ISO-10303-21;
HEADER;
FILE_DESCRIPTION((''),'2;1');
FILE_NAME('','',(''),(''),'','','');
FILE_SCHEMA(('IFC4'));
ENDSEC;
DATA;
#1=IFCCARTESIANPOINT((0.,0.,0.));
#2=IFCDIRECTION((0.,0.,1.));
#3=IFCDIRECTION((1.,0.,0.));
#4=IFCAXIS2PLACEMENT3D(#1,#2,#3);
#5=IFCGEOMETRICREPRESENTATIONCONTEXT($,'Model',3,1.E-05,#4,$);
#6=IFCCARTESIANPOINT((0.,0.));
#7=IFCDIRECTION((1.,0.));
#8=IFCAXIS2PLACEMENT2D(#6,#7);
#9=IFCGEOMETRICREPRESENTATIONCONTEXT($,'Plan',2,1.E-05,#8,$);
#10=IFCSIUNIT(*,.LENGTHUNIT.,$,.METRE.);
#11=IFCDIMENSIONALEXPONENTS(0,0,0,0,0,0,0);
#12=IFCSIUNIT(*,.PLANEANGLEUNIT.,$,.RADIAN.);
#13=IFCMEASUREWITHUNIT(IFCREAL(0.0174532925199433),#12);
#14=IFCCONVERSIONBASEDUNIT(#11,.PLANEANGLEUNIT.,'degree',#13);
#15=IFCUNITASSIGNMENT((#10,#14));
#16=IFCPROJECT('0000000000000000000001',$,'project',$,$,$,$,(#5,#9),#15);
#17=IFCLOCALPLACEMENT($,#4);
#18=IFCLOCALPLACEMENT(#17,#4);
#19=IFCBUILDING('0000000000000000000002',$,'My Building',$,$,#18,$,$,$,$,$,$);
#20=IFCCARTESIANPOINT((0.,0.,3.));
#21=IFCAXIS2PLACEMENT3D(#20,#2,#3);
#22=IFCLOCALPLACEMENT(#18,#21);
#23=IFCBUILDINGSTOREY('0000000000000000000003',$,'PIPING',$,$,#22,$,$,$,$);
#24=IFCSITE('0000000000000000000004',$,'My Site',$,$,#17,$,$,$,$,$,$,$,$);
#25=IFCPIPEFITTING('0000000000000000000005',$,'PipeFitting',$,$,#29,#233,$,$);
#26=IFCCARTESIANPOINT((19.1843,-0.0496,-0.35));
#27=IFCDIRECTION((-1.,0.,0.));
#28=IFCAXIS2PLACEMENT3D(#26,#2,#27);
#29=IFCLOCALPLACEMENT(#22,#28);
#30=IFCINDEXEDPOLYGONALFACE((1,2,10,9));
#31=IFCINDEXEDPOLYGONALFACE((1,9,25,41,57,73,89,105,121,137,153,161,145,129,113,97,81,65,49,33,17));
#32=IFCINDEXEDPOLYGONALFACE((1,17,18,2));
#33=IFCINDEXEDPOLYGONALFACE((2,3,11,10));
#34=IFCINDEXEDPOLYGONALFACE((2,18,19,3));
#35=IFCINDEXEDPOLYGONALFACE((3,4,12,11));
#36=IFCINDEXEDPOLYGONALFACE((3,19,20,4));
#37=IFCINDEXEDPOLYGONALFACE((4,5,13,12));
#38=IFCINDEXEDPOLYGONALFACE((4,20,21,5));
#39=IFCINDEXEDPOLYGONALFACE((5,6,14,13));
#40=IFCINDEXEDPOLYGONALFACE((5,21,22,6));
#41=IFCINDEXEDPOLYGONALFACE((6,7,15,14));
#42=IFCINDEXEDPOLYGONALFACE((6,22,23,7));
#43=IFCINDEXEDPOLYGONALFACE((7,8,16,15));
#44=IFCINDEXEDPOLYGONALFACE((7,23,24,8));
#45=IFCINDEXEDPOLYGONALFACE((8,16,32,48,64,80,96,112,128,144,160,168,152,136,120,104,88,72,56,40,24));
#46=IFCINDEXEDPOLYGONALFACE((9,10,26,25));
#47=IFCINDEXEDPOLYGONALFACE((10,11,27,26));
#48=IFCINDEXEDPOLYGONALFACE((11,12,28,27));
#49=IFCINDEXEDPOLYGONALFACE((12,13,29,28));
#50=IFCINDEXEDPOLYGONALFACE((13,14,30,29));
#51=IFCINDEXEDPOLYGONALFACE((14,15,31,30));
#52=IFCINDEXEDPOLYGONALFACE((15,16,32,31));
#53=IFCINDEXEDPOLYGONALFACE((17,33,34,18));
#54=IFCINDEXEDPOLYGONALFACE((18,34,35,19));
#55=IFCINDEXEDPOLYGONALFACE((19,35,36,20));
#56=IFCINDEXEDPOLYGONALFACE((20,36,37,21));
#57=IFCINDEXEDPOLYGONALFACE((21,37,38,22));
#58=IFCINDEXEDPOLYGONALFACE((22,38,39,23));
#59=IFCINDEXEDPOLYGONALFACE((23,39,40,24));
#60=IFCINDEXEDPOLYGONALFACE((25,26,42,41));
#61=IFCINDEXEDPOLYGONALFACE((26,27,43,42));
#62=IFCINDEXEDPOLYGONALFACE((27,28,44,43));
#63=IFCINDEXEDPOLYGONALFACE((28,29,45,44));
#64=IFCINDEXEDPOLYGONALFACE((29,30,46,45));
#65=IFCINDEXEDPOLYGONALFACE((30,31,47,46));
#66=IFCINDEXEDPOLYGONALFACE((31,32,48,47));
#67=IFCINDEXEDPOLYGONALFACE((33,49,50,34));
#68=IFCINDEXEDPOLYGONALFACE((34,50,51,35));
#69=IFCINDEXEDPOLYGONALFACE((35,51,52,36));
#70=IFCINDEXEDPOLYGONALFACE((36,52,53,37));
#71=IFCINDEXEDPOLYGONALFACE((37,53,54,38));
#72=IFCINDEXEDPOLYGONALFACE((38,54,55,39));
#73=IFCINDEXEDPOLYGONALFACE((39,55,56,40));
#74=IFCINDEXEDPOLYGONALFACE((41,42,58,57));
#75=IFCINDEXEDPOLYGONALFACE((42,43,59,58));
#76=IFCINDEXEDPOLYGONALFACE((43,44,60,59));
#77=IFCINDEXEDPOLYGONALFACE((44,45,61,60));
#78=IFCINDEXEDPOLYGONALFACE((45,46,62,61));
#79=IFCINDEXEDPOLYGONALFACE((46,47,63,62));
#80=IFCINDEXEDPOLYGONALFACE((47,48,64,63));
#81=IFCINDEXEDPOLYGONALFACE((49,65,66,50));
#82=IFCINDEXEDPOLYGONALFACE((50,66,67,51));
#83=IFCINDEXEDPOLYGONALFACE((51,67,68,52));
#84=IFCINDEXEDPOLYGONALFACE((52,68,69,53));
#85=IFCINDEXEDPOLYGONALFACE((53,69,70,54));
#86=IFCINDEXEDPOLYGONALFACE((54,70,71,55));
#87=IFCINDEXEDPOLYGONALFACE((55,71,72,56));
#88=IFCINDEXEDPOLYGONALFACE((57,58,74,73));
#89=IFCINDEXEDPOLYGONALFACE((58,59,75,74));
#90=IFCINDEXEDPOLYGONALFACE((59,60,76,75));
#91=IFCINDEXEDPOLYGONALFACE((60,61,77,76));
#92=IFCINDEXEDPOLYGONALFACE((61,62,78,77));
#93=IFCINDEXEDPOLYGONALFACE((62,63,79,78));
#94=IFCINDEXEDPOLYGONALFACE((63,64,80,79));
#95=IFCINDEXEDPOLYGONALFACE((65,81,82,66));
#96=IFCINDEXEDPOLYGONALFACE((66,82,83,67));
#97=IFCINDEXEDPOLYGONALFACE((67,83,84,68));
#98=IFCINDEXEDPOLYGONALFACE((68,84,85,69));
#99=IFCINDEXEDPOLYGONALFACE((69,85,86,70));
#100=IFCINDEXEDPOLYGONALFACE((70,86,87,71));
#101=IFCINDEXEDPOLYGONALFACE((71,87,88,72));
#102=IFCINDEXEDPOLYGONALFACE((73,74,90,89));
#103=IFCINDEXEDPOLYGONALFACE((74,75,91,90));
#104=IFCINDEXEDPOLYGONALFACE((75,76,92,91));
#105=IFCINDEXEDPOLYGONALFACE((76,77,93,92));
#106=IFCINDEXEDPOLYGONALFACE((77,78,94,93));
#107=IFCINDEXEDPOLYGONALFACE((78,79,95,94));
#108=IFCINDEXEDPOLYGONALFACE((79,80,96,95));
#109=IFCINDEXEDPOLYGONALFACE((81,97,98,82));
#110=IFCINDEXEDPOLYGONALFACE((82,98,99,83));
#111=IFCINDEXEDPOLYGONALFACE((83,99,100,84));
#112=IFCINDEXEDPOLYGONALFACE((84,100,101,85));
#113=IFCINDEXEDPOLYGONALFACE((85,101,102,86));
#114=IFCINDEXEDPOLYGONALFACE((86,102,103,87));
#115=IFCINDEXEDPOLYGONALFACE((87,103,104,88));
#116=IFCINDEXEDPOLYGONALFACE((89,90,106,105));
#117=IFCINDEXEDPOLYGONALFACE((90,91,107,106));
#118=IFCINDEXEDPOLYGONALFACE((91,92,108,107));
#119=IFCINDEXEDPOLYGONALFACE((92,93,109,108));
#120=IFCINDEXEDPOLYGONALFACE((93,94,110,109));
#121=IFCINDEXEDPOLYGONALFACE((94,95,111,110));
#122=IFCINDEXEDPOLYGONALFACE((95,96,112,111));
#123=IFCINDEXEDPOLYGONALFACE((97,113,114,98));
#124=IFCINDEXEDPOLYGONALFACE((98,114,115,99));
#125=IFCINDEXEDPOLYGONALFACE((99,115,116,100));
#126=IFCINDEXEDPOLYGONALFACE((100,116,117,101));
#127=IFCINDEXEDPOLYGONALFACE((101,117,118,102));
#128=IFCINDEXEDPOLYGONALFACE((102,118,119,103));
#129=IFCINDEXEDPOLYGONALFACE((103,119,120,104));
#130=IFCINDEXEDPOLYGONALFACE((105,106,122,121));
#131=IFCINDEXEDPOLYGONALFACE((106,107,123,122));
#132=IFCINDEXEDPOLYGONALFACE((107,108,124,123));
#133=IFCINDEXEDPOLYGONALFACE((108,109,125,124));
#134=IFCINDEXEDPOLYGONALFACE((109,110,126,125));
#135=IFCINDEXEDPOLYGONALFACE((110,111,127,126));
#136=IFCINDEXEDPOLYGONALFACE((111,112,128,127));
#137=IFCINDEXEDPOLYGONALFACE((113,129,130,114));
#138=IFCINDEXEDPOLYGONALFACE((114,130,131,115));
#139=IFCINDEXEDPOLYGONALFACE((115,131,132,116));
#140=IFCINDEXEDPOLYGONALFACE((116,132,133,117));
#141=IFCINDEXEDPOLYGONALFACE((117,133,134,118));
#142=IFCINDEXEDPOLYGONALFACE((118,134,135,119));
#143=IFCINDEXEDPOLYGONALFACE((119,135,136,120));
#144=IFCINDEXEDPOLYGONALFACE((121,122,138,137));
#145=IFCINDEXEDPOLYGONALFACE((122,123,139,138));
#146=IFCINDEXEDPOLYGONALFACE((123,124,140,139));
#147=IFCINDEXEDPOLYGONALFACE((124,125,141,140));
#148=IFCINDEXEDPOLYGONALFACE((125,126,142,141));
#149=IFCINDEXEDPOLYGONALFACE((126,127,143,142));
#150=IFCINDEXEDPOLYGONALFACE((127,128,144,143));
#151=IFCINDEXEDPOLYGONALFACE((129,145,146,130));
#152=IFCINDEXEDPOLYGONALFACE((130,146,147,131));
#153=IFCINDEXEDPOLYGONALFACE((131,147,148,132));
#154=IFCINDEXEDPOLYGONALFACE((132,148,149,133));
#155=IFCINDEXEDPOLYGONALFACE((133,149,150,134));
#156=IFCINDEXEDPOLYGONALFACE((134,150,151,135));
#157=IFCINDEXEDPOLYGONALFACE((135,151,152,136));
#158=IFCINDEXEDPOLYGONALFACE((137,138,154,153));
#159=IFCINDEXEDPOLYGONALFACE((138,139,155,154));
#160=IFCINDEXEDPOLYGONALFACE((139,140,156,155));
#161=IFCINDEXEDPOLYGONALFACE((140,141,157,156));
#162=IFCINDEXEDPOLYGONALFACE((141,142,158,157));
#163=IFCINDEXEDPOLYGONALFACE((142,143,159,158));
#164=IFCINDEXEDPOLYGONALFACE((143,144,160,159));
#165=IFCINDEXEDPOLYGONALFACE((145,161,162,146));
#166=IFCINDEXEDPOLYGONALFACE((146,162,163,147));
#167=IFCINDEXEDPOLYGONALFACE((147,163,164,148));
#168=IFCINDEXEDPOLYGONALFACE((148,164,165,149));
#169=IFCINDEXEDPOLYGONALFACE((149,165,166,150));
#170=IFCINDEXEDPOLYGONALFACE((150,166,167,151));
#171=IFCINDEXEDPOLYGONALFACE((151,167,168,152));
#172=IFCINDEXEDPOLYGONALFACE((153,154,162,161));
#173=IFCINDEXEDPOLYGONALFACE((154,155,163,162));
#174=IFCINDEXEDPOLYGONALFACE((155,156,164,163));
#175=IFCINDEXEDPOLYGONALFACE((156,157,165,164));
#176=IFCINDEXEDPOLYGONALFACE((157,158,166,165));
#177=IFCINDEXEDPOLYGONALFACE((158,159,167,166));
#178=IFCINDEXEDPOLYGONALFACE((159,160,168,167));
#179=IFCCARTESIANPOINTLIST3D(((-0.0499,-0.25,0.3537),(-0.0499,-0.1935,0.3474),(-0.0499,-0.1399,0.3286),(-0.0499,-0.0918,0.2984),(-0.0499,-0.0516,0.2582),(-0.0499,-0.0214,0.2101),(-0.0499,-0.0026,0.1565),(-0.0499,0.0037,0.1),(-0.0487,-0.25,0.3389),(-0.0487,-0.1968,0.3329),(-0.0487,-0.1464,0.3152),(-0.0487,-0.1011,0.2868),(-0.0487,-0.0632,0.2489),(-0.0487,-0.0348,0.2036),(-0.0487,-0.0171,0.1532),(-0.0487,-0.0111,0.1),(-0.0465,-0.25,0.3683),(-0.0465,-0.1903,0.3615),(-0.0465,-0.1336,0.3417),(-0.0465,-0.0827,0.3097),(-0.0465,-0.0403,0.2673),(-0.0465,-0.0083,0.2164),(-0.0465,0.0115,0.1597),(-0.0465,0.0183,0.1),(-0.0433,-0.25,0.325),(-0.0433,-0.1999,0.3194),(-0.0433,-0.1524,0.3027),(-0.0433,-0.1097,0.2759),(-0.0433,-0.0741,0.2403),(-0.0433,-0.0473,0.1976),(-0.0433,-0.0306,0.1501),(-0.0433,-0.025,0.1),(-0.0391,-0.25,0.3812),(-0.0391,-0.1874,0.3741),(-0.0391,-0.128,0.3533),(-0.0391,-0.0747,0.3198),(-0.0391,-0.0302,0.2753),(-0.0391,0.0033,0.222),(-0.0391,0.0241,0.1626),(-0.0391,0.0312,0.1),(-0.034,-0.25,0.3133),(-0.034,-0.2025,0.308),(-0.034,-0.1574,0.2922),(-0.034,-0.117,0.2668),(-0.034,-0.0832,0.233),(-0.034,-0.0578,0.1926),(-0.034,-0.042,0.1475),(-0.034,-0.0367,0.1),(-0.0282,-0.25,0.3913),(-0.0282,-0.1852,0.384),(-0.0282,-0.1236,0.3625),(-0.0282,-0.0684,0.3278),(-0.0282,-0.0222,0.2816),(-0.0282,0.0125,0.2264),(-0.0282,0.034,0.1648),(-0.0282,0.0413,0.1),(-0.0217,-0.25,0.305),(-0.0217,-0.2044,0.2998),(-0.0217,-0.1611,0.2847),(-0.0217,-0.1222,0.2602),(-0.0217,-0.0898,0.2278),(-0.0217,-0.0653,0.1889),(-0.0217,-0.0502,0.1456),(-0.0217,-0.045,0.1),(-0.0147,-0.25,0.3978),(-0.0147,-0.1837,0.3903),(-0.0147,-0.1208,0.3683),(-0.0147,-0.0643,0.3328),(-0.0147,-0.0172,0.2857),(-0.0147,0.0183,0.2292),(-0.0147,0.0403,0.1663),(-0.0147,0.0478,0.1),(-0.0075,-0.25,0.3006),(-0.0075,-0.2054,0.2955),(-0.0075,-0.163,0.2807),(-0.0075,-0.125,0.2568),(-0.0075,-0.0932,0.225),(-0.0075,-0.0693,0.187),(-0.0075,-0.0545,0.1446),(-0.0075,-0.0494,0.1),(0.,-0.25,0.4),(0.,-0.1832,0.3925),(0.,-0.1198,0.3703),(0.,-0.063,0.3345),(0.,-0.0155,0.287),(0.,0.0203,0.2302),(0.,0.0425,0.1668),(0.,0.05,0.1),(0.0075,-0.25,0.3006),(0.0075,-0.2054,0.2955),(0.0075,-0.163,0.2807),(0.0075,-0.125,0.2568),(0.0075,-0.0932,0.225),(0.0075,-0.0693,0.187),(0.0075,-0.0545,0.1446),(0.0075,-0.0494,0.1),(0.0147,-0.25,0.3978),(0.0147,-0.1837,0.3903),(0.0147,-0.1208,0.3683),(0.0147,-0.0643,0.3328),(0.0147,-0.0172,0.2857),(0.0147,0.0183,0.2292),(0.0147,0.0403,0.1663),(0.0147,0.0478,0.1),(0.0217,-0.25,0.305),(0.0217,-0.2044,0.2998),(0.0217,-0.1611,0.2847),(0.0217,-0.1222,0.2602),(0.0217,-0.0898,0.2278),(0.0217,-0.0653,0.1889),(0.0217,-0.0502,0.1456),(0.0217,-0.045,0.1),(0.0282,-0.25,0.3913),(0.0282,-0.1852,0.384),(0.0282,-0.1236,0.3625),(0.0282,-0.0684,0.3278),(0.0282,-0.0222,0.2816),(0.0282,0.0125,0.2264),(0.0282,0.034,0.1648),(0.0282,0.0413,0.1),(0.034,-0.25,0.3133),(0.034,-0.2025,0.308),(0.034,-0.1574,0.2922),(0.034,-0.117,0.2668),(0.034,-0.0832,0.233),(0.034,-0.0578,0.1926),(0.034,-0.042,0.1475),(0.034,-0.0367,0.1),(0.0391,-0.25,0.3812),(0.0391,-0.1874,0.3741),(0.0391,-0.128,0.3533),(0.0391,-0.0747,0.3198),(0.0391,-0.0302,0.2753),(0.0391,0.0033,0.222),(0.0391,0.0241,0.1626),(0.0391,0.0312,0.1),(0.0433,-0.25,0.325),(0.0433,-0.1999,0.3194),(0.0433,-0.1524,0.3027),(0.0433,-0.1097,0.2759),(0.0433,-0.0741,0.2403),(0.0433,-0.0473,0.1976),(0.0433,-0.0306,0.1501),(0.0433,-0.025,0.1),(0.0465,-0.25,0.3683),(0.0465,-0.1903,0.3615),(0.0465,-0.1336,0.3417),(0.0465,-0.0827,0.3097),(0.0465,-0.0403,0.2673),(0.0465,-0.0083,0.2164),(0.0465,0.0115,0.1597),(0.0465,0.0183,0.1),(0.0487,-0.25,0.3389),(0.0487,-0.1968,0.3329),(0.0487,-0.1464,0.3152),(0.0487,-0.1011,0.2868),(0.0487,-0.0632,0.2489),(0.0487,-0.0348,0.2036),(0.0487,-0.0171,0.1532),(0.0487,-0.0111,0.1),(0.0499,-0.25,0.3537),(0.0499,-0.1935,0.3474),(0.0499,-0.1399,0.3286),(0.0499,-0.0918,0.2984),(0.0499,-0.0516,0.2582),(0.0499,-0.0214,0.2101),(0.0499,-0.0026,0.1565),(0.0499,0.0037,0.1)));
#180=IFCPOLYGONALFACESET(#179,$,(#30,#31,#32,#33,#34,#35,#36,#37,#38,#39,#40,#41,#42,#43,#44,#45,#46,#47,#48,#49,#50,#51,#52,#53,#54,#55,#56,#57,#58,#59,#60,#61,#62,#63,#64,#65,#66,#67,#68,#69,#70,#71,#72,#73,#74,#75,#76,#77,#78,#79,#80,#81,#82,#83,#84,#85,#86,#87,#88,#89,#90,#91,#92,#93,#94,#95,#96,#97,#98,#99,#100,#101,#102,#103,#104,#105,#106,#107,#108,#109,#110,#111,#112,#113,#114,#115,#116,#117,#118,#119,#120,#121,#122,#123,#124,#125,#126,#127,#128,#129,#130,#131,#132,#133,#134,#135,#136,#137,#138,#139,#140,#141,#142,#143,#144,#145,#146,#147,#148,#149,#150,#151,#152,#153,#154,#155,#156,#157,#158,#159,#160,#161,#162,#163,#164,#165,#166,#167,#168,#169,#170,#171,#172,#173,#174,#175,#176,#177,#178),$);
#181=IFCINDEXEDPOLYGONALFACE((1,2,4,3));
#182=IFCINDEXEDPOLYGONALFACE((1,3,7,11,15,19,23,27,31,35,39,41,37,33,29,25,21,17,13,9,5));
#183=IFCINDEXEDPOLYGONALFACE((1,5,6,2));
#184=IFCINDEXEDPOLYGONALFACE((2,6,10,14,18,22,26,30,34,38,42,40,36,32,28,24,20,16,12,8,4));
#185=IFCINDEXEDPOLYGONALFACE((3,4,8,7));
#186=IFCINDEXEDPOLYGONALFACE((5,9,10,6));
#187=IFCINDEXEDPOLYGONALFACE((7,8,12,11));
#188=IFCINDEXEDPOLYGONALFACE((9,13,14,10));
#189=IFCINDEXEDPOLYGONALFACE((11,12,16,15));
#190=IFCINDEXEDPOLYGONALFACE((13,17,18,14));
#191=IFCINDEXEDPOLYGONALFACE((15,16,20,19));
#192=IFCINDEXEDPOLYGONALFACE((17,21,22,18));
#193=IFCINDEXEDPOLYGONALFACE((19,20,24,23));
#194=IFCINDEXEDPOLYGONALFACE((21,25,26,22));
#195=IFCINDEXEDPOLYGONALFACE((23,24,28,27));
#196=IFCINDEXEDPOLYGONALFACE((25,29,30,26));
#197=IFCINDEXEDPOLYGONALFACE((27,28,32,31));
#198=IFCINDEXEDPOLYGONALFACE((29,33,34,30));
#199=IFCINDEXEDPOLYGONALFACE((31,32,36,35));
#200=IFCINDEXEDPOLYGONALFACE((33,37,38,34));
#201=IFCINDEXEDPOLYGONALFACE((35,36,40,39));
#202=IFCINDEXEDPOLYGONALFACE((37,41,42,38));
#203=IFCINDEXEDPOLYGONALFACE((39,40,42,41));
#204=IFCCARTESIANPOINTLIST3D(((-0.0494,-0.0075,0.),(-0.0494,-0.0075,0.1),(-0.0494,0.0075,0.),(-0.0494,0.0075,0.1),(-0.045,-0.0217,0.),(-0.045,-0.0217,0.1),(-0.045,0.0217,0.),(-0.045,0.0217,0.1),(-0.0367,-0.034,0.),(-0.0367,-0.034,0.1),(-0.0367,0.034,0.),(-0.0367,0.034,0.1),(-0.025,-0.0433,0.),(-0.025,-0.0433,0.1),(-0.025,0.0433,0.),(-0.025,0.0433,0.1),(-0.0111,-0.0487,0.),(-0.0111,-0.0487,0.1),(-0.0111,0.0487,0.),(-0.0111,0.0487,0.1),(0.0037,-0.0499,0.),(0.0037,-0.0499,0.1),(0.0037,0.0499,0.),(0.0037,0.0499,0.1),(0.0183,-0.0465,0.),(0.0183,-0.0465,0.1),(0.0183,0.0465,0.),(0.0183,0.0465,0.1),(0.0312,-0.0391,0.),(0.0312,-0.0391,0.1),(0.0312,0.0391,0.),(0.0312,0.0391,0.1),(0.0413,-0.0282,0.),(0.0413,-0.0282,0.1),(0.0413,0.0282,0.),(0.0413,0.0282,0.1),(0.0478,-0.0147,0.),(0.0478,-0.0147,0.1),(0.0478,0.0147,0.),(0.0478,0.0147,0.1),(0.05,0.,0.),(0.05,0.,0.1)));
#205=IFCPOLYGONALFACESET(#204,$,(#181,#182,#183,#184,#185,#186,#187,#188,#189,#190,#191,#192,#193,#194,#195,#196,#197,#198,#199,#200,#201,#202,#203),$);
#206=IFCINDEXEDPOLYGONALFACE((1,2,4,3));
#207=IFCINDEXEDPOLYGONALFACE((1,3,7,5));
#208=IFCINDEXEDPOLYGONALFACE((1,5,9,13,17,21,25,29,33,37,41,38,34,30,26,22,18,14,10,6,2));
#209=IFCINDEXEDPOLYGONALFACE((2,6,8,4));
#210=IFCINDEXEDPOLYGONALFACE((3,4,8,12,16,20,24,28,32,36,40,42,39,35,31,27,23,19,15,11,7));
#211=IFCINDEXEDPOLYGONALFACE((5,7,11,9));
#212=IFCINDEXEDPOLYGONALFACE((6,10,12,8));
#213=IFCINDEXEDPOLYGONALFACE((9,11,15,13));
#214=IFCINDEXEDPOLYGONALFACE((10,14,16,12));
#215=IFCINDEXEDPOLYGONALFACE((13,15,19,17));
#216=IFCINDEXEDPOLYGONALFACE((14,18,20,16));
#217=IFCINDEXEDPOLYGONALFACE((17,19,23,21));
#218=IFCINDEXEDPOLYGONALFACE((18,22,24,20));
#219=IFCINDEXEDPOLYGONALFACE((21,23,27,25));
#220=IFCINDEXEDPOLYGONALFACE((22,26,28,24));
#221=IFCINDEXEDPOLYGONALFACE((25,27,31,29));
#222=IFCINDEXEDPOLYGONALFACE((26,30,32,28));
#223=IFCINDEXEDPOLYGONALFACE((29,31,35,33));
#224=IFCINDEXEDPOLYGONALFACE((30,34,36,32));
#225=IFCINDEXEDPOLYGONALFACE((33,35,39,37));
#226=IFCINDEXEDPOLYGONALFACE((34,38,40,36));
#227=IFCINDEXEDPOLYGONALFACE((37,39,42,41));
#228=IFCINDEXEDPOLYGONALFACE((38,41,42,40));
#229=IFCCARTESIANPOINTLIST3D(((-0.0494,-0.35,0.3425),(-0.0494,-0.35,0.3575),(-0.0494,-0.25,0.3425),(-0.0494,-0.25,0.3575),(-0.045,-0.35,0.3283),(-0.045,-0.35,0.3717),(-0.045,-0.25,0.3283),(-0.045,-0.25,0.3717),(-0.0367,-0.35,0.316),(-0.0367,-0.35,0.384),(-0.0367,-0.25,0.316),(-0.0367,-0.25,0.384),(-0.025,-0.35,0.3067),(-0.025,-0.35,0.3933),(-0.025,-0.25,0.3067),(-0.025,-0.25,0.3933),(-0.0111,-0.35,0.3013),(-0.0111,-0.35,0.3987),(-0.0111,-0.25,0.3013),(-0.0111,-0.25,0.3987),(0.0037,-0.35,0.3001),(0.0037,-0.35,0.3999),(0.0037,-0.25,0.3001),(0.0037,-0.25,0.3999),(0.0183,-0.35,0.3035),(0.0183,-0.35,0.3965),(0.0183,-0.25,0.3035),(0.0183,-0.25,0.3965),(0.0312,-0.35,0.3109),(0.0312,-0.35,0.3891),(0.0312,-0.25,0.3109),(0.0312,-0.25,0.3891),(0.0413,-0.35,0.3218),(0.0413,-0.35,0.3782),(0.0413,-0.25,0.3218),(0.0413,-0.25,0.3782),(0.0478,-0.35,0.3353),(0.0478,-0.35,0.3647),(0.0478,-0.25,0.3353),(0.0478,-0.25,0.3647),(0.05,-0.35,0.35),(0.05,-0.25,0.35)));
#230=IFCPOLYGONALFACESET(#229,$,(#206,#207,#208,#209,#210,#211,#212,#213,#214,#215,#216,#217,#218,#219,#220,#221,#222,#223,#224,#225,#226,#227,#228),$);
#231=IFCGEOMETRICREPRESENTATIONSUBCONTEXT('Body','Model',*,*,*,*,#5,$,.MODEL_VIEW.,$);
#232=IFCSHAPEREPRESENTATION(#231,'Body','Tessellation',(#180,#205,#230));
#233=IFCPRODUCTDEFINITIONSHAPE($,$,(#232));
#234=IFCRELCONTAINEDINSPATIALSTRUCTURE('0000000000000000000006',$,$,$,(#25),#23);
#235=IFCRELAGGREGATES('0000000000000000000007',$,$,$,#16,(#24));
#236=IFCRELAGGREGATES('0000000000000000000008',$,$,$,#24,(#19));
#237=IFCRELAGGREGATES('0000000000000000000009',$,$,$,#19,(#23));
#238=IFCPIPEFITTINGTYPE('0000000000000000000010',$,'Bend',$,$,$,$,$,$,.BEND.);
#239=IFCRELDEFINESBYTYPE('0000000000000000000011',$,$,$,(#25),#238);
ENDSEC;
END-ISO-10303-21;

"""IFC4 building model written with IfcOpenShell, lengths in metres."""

from ifc_helpers import new_model, entity, si_unit, converted_unit, frame, origin_with_axes, origin_2d_with_axis, place, context, subcontext, project, spatial, line, indexed_curve, circle, outline, extrude, source, transform, mapped, type_object, type_shapes, element, save


model = new_model("IFC4")

# Units and contexts
model_context = context("Model", 3, precision=1e-05, world=origin_with_axes())
plan_context = context("Plan", 2, precision=1e-05, world=origin_2d_with_axis())
body_context = subcontext(model_context, "Body", "Model", "MODEL_VIEW")
ifc_project = project(units=[si_unit("LENGTHUNIT", "METRE"), converted_unit("PLANEANGLEUNIT", "degree", entity("IfcReal", 0.0174532925199433), si_unit("PLANEANGLEUNIT", "RADIAN"), dimensions=[0, 0, 0, 0, 0, 0, 0])], contexts=[model_context, plan_context])

# Site, building, storey
site_placement = place(None, origin_with_axes())
site = spatial("IfcSite", under=ifc_project, at=site_placement, Name="My Site")
building_placement = place(site_placement, origin_with_axes())
building = spatial("IfcBuilding", under=site, at=building_placement, Name="My Building")
storey_placement = place(building_placement, frame((0.0, 0.0, 3.0), z_axis=(0.0, 0.0, 1.0), x_axis=(1.0, 0.0, 0.0)))
storey = spatial("IfcBuildingStorey", under=building, at=storey_placement, Name="PIPING")

# Pipe fitting, opening
pipe_fitting_type = type_object("IfcPipeFittingType", Name="Bend", PredefinedType="BEND")
shared_shape = source(origin_with_axes(), body_context, "Body", "SolidModel", [
    entity("IfcSweptDiskSolid", entity("IfcIndexedPolyCurve", entity("IfcCartesianPointList3D", [[0.0, 0.0, 0.1], [0.0, -0.0732, 0.2768], [0.0, -0.25, 0.35]]), [entity("IfcArcIndex", [1, 2, 3])]), 0.05),
    extrude(circle(Radius=0.05), origin_with_axes(), (0.0, 0.0, 1.0), 0.1),
    extrude(circle(Radius=0.05), frame((0.0, -0.25, 0.35), z_axis=(0.0, -1.0, 0.0), x_axis=(1.0, 0.0, 0.0)), (0.0, 0.0, 1.0), 0.1),
])
type_shapes(pipe_fitting_type, [shared_shape])
pipe_fitting_1_placement = place(storey_placement, frame((19.1843, -0.0496, -0.35), z_axis=(0.0, 0.0, 1.0), x_axis=(-1.0, 0.0, 0.0)))
pipe_fitting_1 = element("IfcPipeFitting", 1, at=pipe_fitting_1_placement, inside=storey, type_object=pipe_fitting_type, Name="PipeFitting", context=body_context, shape_type="MappedRepresentation", body=[
    mapped(shared_shape, transform((0.0, 0.0, 0.0), x_axis=(1.0, 0.0, 0.0), y_axis=(0.0, 1.0, 0.0), z_axis=(0.0, 0.0, 1.0), scale=1.0)),
])
opening_1_placement = place(pipe_fitting_1_placement, frame((19.1843, -0.0496, -2.65), z_axis=(0.0, 0.0, 1.0), x_axis=(-1.0, 0.0, 0.0)))
element("IfcOpeningElement", 2, at=opening_1_placement, cuts=pipe_fitting_1, PredefinedType="OPENING", context=body_context, shape_type="SweptSolid", body=[
    extrude(outline(indexed_curve([(0.0, 0.0), (0.5, 0.0), (0.5, 0.5), (0.0, 0.5)], segments=[line(1, 2, 3, 4, 1)])), origin_with_axes(), (0.0, 0.0, 1.0), 0.5),
])

save(model, "model.ifc")
